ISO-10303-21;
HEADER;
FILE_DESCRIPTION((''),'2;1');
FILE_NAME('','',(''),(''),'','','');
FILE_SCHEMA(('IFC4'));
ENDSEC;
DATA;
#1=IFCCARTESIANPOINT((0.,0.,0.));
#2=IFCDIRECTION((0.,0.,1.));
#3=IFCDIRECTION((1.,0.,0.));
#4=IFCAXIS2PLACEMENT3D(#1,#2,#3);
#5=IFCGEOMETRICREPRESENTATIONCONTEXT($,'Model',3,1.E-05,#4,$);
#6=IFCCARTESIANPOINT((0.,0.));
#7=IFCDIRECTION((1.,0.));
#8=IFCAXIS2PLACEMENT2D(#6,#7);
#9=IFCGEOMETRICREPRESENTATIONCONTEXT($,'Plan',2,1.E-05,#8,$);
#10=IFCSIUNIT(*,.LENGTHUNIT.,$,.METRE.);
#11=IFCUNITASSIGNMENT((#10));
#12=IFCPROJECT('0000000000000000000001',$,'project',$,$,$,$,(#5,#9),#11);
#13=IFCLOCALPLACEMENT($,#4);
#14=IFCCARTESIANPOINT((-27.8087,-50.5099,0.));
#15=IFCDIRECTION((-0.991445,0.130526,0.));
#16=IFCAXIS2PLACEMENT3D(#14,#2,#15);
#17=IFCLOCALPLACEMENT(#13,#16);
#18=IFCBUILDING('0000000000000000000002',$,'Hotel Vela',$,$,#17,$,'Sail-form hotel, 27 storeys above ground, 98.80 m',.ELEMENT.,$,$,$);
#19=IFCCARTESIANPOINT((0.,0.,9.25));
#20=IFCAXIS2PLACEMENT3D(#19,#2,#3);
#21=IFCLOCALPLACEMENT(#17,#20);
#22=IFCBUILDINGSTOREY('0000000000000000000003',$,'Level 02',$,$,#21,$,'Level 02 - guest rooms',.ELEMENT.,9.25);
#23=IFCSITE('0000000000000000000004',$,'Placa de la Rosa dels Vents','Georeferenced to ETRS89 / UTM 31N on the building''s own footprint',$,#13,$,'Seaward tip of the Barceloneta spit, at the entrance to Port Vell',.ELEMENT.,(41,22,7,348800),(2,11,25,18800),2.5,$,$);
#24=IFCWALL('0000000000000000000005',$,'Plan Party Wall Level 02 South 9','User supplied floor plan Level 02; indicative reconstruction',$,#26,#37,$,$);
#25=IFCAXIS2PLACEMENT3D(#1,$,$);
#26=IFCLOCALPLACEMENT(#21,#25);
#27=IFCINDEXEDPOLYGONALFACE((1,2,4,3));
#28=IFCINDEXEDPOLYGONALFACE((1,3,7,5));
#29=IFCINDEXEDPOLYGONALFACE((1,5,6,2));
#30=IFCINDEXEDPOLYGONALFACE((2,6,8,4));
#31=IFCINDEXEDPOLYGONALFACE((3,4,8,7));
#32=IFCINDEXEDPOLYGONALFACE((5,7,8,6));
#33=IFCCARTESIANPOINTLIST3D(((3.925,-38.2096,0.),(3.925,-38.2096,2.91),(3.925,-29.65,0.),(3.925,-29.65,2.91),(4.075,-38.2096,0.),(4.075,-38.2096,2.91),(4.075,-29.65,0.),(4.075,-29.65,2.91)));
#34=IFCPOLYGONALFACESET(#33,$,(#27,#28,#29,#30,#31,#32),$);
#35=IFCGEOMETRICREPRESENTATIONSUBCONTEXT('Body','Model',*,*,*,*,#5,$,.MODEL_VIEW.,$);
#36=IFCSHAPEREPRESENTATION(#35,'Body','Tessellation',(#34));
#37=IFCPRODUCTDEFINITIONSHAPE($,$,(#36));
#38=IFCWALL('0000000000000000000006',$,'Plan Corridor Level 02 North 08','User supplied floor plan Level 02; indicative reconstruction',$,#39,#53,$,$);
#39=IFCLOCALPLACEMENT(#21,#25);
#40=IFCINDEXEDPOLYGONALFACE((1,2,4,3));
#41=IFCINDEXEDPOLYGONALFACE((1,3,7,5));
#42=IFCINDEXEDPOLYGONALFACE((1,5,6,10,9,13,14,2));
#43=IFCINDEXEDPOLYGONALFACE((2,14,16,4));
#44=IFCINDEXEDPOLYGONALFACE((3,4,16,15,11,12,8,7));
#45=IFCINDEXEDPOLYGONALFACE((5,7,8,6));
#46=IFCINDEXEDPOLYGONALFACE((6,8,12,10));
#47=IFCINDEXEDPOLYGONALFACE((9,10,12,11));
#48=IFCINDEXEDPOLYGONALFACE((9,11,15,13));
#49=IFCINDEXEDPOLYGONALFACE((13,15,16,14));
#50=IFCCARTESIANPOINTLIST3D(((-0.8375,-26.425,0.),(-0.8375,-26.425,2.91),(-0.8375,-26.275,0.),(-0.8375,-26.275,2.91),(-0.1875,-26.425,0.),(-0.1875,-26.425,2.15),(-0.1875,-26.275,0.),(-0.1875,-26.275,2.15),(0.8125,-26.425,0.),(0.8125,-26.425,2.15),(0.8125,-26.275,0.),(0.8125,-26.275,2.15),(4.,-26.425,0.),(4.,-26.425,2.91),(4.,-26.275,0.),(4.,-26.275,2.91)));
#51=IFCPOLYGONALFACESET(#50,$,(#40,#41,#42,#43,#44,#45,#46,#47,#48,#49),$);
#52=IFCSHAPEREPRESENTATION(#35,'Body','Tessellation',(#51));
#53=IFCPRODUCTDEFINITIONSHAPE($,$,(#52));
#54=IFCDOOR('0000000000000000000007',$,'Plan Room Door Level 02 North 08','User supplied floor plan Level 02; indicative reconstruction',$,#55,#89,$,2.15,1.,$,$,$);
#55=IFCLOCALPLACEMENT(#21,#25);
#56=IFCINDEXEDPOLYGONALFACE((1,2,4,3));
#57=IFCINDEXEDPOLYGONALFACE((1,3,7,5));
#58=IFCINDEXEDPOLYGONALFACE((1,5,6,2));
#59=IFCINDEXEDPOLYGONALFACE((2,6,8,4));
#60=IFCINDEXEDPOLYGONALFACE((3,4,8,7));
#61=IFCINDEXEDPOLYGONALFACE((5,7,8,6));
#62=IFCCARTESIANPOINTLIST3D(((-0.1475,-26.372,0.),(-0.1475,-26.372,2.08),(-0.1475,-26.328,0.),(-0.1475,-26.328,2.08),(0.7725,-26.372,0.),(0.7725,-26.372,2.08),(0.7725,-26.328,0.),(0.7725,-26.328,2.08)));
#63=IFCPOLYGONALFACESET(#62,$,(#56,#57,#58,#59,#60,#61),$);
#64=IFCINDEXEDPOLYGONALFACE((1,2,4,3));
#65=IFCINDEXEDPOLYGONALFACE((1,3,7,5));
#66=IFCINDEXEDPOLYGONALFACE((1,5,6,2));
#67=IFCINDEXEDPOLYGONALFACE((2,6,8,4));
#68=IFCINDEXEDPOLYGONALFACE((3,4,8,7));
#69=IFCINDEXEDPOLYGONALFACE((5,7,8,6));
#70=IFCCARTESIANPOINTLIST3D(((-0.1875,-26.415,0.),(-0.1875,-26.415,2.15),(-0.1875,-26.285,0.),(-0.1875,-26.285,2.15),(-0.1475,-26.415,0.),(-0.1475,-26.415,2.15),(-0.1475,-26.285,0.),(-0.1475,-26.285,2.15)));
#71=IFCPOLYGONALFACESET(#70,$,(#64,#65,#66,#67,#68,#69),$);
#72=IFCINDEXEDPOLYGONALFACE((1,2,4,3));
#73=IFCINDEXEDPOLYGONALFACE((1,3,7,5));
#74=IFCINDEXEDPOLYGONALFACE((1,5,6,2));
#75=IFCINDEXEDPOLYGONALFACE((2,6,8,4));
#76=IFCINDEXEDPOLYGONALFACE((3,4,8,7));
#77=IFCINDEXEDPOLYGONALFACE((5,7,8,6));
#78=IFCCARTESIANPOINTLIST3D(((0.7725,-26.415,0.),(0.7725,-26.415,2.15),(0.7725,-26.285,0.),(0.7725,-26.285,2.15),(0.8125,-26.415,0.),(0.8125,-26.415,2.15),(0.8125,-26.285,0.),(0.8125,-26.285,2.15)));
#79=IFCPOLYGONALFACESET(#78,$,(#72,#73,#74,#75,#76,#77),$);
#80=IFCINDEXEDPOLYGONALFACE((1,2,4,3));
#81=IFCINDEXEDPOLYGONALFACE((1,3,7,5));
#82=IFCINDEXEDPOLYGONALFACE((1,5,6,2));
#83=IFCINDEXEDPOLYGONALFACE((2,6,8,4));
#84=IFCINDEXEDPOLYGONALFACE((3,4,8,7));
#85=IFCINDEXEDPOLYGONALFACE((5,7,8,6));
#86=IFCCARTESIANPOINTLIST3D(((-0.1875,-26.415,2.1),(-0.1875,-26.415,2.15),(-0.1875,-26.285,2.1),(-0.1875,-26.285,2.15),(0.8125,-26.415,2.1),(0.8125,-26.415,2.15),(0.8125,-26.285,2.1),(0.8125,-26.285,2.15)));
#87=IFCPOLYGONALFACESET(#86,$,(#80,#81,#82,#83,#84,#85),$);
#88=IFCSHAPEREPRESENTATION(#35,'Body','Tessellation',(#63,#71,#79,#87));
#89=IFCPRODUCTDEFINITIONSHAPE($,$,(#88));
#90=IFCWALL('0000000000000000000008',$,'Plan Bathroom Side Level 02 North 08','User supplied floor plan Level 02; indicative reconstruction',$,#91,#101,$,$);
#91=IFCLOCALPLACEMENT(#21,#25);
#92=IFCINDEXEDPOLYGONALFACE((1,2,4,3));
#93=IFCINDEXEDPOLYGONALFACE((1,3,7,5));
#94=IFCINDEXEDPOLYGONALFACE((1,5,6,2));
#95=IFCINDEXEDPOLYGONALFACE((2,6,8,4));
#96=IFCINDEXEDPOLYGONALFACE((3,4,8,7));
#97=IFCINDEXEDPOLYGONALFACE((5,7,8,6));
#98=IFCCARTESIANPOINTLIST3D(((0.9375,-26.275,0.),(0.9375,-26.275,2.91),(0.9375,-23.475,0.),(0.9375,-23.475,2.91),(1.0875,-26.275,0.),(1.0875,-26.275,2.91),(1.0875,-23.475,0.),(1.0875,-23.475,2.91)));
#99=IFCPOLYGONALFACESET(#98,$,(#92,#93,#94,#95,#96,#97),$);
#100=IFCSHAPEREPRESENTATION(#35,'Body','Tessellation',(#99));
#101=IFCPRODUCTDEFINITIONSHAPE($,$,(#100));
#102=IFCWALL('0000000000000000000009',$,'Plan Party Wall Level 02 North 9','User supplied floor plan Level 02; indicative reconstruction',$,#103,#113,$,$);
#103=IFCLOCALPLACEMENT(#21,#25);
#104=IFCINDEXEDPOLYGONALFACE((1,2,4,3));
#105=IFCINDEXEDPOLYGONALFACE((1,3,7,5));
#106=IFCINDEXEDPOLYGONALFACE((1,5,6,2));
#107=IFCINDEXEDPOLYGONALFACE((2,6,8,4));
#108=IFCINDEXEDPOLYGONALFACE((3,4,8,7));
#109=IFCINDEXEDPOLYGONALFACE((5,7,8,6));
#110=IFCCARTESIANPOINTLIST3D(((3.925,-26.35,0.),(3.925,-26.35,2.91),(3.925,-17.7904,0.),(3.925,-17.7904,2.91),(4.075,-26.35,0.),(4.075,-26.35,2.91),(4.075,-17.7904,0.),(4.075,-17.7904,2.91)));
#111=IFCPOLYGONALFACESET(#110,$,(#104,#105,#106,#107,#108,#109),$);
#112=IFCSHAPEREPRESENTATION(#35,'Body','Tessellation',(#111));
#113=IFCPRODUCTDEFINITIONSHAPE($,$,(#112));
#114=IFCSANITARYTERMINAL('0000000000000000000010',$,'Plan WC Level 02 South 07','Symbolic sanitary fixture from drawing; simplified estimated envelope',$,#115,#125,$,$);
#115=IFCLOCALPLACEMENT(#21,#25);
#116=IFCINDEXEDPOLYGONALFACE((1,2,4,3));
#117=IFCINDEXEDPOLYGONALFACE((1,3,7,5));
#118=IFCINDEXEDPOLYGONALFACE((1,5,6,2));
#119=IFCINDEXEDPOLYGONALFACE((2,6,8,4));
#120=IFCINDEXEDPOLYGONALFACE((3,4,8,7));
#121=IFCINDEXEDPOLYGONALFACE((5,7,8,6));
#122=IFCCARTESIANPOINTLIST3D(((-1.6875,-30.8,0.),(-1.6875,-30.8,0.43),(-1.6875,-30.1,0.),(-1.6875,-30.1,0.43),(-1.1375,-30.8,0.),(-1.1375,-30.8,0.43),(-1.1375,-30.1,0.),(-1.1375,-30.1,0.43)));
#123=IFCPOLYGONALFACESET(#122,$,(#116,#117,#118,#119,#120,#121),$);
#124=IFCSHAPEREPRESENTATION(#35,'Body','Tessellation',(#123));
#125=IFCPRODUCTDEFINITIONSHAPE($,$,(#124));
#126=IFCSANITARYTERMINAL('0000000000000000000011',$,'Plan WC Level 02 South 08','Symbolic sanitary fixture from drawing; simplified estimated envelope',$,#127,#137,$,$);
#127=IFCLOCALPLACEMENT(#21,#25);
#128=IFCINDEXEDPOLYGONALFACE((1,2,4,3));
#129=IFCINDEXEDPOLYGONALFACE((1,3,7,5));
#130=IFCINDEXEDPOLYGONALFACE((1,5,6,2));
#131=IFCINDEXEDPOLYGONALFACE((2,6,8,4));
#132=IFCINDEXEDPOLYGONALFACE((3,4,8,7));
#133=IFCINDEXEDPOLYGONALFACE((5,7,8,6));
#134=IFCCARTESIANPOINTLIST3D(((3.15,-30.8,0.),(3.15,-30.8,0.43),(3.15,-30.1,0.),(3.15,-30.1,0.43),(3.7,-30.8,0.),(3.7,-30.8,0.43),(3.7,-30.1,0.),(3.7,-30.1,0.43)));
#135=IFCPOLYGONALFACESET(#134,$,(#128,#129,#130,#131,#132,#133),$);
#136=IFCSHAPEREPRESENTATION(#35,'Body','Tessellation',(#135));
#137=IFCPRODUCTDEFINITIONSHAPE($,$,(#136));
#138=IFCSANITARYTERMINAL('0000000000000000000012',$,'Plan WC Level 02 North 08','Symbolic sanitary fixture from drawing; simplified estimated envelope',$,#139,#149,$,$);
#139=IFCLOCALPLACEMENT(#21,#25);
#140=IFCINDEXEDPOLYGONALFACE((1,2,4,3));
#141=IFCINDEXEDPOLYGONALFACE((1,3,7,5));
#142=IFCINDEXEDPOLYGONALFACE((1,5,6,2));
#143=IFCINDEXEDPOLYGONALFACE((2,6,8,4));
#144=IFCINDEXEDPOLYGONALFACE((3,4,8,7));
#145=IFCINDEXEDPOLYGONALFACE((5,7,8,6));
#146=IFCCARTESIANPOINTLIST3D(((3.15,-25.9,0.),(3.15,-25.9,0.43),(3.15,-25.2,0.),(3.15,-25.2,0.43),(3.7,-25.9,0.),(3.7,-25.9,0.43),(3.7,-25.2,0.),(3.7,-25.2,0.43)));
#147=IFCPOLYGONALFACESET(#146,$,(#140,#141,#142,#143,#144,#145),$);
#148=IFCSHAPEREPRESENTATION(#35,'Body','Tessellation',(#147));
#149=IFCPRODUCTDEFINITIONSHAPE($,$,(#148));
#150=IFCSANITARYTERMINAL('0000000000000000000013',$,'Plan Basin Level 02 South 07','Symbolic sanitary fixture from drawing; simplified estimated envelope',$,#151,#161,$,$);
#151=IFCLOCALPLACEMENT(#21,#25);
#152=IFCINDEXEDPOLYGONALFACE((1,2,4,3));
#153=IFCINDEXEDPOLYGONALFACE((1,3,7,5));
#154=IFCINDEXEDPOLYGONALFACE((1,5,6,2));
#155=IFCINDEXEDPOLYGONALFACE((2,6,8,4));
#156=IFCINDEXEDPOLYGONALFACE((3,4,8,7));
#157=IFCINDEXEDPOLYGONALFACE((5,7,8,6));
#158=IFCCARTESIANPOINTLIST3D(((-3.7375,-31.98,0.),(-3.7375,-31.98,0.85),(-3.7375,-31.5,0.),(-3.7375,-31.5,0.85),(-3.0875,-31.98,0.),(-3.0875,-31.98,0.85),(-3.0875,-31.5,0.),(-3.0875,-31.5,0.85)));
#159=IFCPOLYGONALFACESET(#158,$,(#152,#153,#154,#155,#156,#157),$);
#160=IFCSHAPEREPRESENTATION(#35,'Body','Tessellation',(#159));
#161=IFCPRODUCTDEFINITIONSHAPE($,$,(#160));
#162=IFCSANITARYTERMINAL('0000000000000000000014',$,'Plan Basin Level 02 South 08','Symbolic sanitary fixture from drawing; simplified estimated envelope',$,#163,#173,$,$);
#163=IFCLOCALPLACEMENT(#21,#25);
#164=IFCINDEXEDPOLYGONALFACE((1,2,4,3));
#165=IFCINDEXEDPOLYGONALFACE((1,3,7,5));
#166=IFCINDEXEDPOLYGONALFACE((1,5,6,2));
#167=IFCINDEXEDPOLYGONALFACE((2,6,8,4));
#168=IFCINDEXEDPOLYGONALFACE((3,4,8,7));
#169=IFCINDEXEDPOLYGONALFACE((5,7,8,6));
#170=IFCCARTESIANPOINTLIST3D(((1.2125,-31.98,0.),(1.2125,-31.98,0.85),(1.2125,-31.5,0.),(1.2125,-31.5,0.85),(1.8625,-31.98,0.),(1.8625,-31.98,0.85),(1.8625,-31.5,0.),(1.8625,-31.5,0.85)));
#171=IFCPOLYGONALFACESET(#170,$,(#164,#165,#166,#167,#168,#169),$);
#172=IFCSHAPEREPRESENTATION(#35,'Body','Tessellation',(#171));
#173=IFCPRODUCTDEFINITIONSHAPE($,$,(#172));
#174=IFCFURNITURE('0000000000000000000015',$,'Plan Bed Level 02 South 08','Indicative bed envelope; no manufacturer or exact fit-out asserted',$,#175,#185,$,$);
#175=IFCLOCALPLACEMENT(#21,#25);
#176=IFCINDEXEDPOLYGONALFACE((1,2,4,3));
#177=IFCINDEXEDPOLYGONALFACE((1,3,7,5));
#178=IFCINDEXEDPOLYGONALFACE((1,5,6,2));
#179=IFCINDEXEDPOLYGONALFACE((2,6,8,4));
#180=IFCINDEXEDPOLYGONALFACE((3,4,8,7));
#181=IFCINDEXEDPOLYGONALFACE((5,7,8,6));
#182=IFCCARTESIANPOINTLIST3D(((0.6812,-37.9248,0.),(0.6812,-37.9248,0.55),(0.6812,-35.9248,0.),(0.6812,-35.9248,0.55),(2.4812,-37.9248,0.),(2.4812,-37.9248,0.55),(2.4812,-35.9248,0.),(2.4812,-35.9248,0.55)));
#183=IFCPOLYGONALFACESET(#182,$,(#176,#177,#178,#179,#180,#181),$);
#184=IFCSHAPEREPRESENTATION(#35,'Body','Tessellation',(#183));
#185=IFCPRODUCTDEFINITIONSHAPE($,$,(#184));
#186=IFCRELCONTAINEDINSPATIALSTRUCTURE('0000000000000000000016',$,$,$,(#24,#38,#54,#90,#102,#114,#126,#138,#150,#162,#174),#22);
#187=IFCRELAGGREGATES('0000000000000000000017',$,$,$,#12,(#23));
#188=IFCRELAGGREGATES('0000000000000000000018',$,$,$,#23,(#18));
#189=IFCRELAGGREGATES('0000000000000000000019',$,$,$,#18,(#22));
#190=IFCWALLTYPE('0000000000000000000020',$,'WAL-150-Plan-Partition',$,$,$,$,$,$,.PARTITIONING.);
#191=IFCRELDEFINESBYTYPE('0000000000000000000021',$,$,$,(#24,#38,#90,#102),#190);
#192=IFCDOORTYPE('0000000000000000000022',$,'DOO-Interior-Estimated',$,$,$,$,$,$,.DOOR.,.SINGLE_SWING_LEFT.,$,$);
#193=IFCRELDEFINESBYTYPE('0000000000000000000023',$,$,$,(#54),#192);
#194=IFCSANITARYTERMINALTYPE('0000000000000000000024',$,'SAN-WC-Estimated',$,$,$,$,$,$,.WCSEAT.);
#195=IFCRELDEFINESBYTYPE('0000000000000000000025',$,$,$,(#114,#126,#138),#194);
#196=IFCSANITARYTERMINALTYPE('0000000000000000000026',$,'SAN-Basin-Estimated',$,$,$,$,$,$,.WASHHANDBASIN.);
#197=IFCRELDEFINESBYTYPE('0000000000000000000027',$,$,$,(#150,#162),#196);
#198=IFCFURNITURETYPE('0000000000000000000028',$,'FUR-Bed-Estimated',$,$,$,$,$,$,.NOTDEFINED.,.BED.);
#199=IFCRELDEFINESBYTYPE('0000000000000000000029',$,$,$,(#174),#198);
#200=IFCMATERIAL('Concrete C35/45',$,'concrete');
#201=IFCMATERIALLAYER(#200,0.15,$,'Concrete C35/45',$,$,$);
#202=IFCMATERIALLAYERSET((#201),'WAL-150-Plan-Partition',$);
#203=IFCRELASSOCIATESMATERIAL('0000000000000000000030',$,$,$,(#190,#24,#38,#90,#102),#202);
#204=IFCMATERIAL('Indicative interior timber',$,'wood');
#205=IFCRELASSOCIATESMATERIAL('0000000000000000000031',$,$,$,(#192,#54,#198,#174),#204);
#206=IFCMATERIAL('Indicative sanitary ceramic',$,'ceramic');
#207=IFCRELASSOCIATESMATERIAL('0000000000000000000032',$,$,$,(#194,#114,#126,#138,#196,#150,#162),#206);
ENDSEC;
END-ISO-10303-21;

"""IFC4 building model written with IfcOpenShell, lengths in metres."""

from ifc_helpers import new_model, si_unit, frame, origin_with_axes, origin_2d_with_axis, place, context, subcontext, project, spatial, line, indexed_curve, outline, extrude, material, layer, layer_set, layer_usage, type_object, element, fill, save


model = new_model("IFC4")

# Units and contexts
model_context = context("Model", 3, precision=1e-05, world=origin_with_axes())
plan_context = context("Plan", 2, precision=1e-05, world=origin_2d_with_axis())
body_context = subcontext(model_context, "Body", "Model", "MODEL_VIEW")
ifc_project = project(units=[si_unit("LENGTHUNIT", "METRE")], contexts=[model_context, plan_context])

# Site, building, storey
site_placement = place(None, origin_with_axes())
site = spatial("IfcSite", under=ifc_project, at=site_placement, Name="Placa de la Rosa dels Vents", Description="Georeferenced to ETRS89 / UTM 31N on the building's own footprint", LongName="Seaward tip of the Barceloneta spit, at the entrance to Port Vell", CompositionType="ELEMENT", RefLatitude=(41, 22, 7, 348800), RefLongitude=(2, 11, 25, 18800), RefElevation=2.5)
building_placement = place(site_placement, frame((-27.8087, -50.5099, 0.0), z_axis=(0.0, 0.0, 1.0), x_axis=(-0.991445, 0.130526, 0.0)))
building = spatial("IfcBuilding", under=site, at=building_placement, Name="Hotel Vela", LongName="Sail-form hotel, 27 storeys above ground, 98.80 m", CompositionType="ELEMENT")
storey_placement = place(building_placement, frame((0.0, 0.0, 9.25), z_axis=(0.0, 0.0, 1.0), x_axis=(1.0, 0.0, 0.0)))
storey = spatial("IfcBuildingStorey", under=building, at=storey_placement, Name="Level 02", LongName="Level 02 - guest rooms", CompositionType="ELEMENT", Elevation=9.25)

# Shared definitions
ifc_material_1 = material(Name="Concrete C35/45", Category="concrete")
ifc_layer_1 = layer(ifc_material_1, 0.15, Name="Concrete C35/45")
ifc_layer_set_1 = layer_set([ifc_layer_1], Name="WAL-150-Plan-Partition")
wall_type = type_object("IfcWallType", Name="WAL-150-Plan-Partition", PredefinedType="PARTITIONING", material=ifc_layer_set_1)
ifc_material_2 = material(Name="Indicative interior timber", Category="wood")
door_type = type_object("IfcDoorType", Name="DOO-Interior-Estimated", OperationType="SINGLE_SWING_LEFT", PredefinedType="DOOR", material=ifc_material_2)

# Wall
ifc_layer_usage_1 = layer_usage(ifc_layer_set_1, "AXIS2", "POSITIVE", 0.0)
wall_1_placement = place(storey_placement, frame((3.925, -38.2096, 0.0), z_axis=(0.0, 0.0, 1.0), x_axis=(1.0, 0.0, 0.0)))
element("IfcWall", 1, at=wall_1_placement, inside=storey, type_object=wall_type, material=ifc_layer_usage_1, Name="Plan Party Wall Level 02 South 9", Description="User supplied floor plan Level 02; indicative reconstruction", context=body_context, shape_type="SweptSolid", body=[
    extrude(outline(indexed_curve([(0.0, 0.0), (0.15, 0.0), (0.15, 8.5596), (0.0, 8.5596)], segments=[line(1, 2, 3, 4, 1)])), origin_with_axes(), (0.0, 0.0, 1.0), 2.91),
])

# Wall, opening, door
ifc_layer_usage_2 = layer_usage(ifc_layer_set_1, "AXIS2", "POSITIVE", 0.0)
wall_2_placement = place(storey_placement, frame((-0.8375, -26.425, 0.0), z_axis=(0.0, 0.0, 1.0), x_axis=(1.0, 0.0, 0.0)))
wall_2 = element("IfcWall", 2, at=wall_2_placement, inside=storey, type_object=wall_type, material=ifc_layer_usage_2, Name="Plan Corridor Level 02 North 08", Description="User supplied floor plan Level 02; indicative reconstruction", context=body_context, shape_type="SweptSolid", body=[
    extrude(outline(indexed_curve([(0.0, 0.0), (4.8375, 0.0), (4.8375, 0.15), (0.0, 0.15)], segments=[line(1, 2, 3, 4, 1)])), origin_with_axes(), (0.0, 0.0, 1.0), 2.91),
])
opening_1_placement = place(wall_2_placement, frame((0.65, -0.085, 0.0), z_axis=(0.0, 0.0, 1.0), x_axis=(1.0, 0.0, 0.0)))
opening_1 = element("IfcOpeningElement", 3, at=opening_1_placement, cuts=wall_2, PredefinedType="OPENING", context=body_context, shape_type="SweptSolid", body=[
    extrude(outline(indexed_curve([(0.0, 0.0), (1.0, 0.0), (1.0, 0.32), (0.0, 0.32)], segments=[line(1, 2, 3, 4, 1)])), origin_with_axes(), (0.0, 0.0, 1.0), 2.15),
])
door_1_placement = place(storey_placement, frame((0.0, 0.0, -9.25), z_axis=(0.0, 0.0, 1.0), x_axis=(1.0, 0.0, 0.0)))
door_1 = element("IfcDoor", 4, at=door_1_placement, inside=storey, type_object=door_type, material=ifc_material_2, Name="Plan Room Door Level 02 North 08", Description="User supplied floor plan Level 02; indicative reconstruction", OverallHeight=2.15, OverallWidth=1.0, context=body_context, shape_type="SweptSolid", body=[
    extrude(outline(indexed_curve([(0.0, 0.0), (0.92, 0.0), (0.92, 0.044), (0.0, 0.044)], segments=[line(1, 2, 3, 4, 1)])), frame((-0.1475, -26.372, 9.25), z_axis=(0.0, 0.0, 1.0), x_axis=(1.0, 0.0, 0.0)), (0.0, 0.0, 1.0), 2.08),
    extrude(outline(indexed_curve([(0.0, 0.0), (0.04, 0.0), (0.04, 0.13), (0.0, 0.13)], segments=[line(1, 2, 3, 4, 1)])), frame((-0.1875, -26.415, 9.25), z_axis=(0.0, 0.0, 1.0), x_axis=(1.0, 0.0, 0.0)), (0.0, 0.0, 1.0), 2.15),
    extrude(outline(indexed_curve([(0.0, 0.0), (0.04, 0.0), (0.04, 0.13), (0.0, 0.13)], segments=[line(1, 2, 3, 4, 1)])), frame((0.7725, -26.415, 9.25), z_axis=(0.0, 0.0, 1.0), x_axis=(1.0, 0.0, 0.0)), (0.0, 0.0, 1.0), 2.15),
    extrude(outline(indexed_curve([(0.0, 0.0), (1.0, 0.0), (1.0, 0.13), (0.0, 0.13)], segments=[line(1, 2, 3, 4, 1)])), frame((-0.1875, -26.415, 11.35), z_axis=(0.0, 0.0, 1.0), x_axis=(1.0, 0.0, 0.0)), (0.0, 0.0, 1.0), 0.05),
])
fill(opening_1, door_1)

# Walls
ifc_layer_usage_3 = layer_usage(ifc_layer_set_1, "AXIS2", "POSITIVE", 0.0)
wall_3_placement = place(storey_placement, frame((0.9375, -26.275, 0.0), z_axis=(0.0, 0.0, 1.0), x_axis=(1.0, 0.0, 0.0)))
element("IfcWall", 5, at=wall_3_placement, inside=storey, type_object=wall_type, material=ifc_layer_usage_3, Name="Plan Bathroom Side Level 02 North 08", Description="User supplied floor plan Level 02; indicative reconstruction", context=body_context, shape_type="SweptSolid", body=[
    extrude(outline(indexed_curve([(0.0, 0.0), (0.15, 0.0), (0.15, 2.8), (0.0, 2.8)], segments=[line(1, 2, 3, 4, 1)])), origin_with_axes(), (0.0, 0.0, 1.0), 2.91),
])
ifc_layer_usage_4 = layer_usage(ifc_layer_set_1, "AXIS2", "POSITIVE", 0.0)
wall_4_placement = place(storey_placement, frame((3.925, -26.35, 0.0), z_axis=(0.0, 0.0, 1.0), x_axis=(1.0, 0.0, 0.0)))
element("IfcWall", 6, at=wall_4_placement, inside=storey, type_object=wall_type, material=ifc_layer_usage_4, Name="Plan Party Wall Level 02 North 9", Description="User supplied floor plan Level 02; indicative reconstruction", context=body_context, shape_type="SweptSolid", body=[
    extrude(outline(indexed_curve([(0.0, 0.0), (0.15, 0.0), (0.15, 8.5596), (0.0, 8.5596)], segments=[line(1, 2, 3, 4, 1)])), origin_with_axes(), (0.0, 0.0, 1.0), 2.91),
])

# Sanitary terminals
ifc_material_3 = material(Name="Indicative sanitary ceramic", Category="ceramic")
sanitary_terminal_type_1 = type_object("IfcSanitaryTerminalType", Name="SAN-WC-Estimated", PredefinedType="WCSEAT", material=ifc_material_3)
for number, where, z_axis, x_axis, name in (
    (7, (-1.6875, -30.8, 0.0), (0.0, 0.0, 1.0), (1.0, 0.0, 0.0), "Plan WC Level 02 South 07"),
    (8, (3.15, -30.8, 0.0), (0.0, 0.0, 1.0), (1.0, 0.0, 0.0), "Plan WC Level 02 South 08"),
    (9, (3.15, -25.9, 0.0), (0.0, 0.0, 1.0), (1.0, 0.0, 0.0), "Plan WC Level 02 North 08"),
):
    element("IfcSanitaryTerminal", number, at=place(storey_placement, frame(where, z_axis=z_axis, x_axis=x_axis)), inside=storey, type_object=sanitary_terminal_type_1, material=ifc_material_3, Name=name, Description="Symbolic sanitary fixture from drawing; simplified estimated envelope", context=body_context, shape_type="SweptSolid", body=[
        extrude(outline(indexed_curve([(0.0, 0.0), (0.55, 0.0), (0.55, 0.7), (0.0, 0.7)], segments=[line(1, 2, 3, 4, 1)])), origin_with_axes(), (0.0, 0.0, 1.0), 0.43),
    ])
sanitary_terminal_type_2 = type_object("IfcSanitaryTerminalType", Name="SAN-Basin-Estimated", PredefinedType="WASHHANDBASIN", material=ifc_material_3)
for number, where, z_axis, x_axis, name in (
    (10, (-3.7375, -31.98, 0.0), (0.0, 0.0, 1.0), (1.0, 0.0, 0.0), "Plan Basin Level 02 South 07"),
    (11, (1.2125, -31.98, 0.0), (0.0, 0.0, 1.0), (1.0, 0.0, 0.0), "Plan Basin Level 02 South 08"),
):
    element("IfcSanitaryTerminal", number, at=place(storey_placement, frame(where, z_axis=z_axis, x_axis=x_axis)), inside=storey, type_object=sanitary_terminal_type_2, material=ifc_material_3, Name=name, Description="Symbolic sanitary fixture from drawing; simplified estimated envelope", context=body_context, shape_type="SweptSolid", body=[
        extrude(outline(indexed_curve([(0.0, 0.0), (0.65, 0.0), (0.65, 0.48), (0.0, 0.48)], segments=[line(1, 2, 3, 4, 1)])), origin_with_axes(), (0.0, 0.0, 1.0), 0.85),
    ])

# Furniture
furniture_type = type_object("IfcFurnitureType", Name="FUR-Bed-Estimated", AssemblyPlace="NOTDEFINED", PredefinedType="BED", material=ifc_material_2)
furniture_placement = place(storey_placement, frame((0.6812, -37.9248, 0.0), z_axis=(0.0, 0.0, 1.0), x_axis=(1.0, 0.0, 0.0)))
element("IfcFurniture", 12, at=furniture_placement, inside=storey, type_object=furniture_type, material=ifc_material_2, Name="Plan Bed Level 02 South 08", Description="Indicative bed envelope; no manufacturer or exact fit-out asserted", context=body_context, shape_type="SweptSolid", body=[
    extrude(outline(indexed_curve([(0.0, 0.0), (1.8, 0.0), (1.8, 2.0), (0.0, 2.0)], segments=[line(1, 2, 3, 4, 1)])), origin_with_axes(), (0.0, 0.0, 1.0), 0.55),
])

save(model, "model.ifc")
